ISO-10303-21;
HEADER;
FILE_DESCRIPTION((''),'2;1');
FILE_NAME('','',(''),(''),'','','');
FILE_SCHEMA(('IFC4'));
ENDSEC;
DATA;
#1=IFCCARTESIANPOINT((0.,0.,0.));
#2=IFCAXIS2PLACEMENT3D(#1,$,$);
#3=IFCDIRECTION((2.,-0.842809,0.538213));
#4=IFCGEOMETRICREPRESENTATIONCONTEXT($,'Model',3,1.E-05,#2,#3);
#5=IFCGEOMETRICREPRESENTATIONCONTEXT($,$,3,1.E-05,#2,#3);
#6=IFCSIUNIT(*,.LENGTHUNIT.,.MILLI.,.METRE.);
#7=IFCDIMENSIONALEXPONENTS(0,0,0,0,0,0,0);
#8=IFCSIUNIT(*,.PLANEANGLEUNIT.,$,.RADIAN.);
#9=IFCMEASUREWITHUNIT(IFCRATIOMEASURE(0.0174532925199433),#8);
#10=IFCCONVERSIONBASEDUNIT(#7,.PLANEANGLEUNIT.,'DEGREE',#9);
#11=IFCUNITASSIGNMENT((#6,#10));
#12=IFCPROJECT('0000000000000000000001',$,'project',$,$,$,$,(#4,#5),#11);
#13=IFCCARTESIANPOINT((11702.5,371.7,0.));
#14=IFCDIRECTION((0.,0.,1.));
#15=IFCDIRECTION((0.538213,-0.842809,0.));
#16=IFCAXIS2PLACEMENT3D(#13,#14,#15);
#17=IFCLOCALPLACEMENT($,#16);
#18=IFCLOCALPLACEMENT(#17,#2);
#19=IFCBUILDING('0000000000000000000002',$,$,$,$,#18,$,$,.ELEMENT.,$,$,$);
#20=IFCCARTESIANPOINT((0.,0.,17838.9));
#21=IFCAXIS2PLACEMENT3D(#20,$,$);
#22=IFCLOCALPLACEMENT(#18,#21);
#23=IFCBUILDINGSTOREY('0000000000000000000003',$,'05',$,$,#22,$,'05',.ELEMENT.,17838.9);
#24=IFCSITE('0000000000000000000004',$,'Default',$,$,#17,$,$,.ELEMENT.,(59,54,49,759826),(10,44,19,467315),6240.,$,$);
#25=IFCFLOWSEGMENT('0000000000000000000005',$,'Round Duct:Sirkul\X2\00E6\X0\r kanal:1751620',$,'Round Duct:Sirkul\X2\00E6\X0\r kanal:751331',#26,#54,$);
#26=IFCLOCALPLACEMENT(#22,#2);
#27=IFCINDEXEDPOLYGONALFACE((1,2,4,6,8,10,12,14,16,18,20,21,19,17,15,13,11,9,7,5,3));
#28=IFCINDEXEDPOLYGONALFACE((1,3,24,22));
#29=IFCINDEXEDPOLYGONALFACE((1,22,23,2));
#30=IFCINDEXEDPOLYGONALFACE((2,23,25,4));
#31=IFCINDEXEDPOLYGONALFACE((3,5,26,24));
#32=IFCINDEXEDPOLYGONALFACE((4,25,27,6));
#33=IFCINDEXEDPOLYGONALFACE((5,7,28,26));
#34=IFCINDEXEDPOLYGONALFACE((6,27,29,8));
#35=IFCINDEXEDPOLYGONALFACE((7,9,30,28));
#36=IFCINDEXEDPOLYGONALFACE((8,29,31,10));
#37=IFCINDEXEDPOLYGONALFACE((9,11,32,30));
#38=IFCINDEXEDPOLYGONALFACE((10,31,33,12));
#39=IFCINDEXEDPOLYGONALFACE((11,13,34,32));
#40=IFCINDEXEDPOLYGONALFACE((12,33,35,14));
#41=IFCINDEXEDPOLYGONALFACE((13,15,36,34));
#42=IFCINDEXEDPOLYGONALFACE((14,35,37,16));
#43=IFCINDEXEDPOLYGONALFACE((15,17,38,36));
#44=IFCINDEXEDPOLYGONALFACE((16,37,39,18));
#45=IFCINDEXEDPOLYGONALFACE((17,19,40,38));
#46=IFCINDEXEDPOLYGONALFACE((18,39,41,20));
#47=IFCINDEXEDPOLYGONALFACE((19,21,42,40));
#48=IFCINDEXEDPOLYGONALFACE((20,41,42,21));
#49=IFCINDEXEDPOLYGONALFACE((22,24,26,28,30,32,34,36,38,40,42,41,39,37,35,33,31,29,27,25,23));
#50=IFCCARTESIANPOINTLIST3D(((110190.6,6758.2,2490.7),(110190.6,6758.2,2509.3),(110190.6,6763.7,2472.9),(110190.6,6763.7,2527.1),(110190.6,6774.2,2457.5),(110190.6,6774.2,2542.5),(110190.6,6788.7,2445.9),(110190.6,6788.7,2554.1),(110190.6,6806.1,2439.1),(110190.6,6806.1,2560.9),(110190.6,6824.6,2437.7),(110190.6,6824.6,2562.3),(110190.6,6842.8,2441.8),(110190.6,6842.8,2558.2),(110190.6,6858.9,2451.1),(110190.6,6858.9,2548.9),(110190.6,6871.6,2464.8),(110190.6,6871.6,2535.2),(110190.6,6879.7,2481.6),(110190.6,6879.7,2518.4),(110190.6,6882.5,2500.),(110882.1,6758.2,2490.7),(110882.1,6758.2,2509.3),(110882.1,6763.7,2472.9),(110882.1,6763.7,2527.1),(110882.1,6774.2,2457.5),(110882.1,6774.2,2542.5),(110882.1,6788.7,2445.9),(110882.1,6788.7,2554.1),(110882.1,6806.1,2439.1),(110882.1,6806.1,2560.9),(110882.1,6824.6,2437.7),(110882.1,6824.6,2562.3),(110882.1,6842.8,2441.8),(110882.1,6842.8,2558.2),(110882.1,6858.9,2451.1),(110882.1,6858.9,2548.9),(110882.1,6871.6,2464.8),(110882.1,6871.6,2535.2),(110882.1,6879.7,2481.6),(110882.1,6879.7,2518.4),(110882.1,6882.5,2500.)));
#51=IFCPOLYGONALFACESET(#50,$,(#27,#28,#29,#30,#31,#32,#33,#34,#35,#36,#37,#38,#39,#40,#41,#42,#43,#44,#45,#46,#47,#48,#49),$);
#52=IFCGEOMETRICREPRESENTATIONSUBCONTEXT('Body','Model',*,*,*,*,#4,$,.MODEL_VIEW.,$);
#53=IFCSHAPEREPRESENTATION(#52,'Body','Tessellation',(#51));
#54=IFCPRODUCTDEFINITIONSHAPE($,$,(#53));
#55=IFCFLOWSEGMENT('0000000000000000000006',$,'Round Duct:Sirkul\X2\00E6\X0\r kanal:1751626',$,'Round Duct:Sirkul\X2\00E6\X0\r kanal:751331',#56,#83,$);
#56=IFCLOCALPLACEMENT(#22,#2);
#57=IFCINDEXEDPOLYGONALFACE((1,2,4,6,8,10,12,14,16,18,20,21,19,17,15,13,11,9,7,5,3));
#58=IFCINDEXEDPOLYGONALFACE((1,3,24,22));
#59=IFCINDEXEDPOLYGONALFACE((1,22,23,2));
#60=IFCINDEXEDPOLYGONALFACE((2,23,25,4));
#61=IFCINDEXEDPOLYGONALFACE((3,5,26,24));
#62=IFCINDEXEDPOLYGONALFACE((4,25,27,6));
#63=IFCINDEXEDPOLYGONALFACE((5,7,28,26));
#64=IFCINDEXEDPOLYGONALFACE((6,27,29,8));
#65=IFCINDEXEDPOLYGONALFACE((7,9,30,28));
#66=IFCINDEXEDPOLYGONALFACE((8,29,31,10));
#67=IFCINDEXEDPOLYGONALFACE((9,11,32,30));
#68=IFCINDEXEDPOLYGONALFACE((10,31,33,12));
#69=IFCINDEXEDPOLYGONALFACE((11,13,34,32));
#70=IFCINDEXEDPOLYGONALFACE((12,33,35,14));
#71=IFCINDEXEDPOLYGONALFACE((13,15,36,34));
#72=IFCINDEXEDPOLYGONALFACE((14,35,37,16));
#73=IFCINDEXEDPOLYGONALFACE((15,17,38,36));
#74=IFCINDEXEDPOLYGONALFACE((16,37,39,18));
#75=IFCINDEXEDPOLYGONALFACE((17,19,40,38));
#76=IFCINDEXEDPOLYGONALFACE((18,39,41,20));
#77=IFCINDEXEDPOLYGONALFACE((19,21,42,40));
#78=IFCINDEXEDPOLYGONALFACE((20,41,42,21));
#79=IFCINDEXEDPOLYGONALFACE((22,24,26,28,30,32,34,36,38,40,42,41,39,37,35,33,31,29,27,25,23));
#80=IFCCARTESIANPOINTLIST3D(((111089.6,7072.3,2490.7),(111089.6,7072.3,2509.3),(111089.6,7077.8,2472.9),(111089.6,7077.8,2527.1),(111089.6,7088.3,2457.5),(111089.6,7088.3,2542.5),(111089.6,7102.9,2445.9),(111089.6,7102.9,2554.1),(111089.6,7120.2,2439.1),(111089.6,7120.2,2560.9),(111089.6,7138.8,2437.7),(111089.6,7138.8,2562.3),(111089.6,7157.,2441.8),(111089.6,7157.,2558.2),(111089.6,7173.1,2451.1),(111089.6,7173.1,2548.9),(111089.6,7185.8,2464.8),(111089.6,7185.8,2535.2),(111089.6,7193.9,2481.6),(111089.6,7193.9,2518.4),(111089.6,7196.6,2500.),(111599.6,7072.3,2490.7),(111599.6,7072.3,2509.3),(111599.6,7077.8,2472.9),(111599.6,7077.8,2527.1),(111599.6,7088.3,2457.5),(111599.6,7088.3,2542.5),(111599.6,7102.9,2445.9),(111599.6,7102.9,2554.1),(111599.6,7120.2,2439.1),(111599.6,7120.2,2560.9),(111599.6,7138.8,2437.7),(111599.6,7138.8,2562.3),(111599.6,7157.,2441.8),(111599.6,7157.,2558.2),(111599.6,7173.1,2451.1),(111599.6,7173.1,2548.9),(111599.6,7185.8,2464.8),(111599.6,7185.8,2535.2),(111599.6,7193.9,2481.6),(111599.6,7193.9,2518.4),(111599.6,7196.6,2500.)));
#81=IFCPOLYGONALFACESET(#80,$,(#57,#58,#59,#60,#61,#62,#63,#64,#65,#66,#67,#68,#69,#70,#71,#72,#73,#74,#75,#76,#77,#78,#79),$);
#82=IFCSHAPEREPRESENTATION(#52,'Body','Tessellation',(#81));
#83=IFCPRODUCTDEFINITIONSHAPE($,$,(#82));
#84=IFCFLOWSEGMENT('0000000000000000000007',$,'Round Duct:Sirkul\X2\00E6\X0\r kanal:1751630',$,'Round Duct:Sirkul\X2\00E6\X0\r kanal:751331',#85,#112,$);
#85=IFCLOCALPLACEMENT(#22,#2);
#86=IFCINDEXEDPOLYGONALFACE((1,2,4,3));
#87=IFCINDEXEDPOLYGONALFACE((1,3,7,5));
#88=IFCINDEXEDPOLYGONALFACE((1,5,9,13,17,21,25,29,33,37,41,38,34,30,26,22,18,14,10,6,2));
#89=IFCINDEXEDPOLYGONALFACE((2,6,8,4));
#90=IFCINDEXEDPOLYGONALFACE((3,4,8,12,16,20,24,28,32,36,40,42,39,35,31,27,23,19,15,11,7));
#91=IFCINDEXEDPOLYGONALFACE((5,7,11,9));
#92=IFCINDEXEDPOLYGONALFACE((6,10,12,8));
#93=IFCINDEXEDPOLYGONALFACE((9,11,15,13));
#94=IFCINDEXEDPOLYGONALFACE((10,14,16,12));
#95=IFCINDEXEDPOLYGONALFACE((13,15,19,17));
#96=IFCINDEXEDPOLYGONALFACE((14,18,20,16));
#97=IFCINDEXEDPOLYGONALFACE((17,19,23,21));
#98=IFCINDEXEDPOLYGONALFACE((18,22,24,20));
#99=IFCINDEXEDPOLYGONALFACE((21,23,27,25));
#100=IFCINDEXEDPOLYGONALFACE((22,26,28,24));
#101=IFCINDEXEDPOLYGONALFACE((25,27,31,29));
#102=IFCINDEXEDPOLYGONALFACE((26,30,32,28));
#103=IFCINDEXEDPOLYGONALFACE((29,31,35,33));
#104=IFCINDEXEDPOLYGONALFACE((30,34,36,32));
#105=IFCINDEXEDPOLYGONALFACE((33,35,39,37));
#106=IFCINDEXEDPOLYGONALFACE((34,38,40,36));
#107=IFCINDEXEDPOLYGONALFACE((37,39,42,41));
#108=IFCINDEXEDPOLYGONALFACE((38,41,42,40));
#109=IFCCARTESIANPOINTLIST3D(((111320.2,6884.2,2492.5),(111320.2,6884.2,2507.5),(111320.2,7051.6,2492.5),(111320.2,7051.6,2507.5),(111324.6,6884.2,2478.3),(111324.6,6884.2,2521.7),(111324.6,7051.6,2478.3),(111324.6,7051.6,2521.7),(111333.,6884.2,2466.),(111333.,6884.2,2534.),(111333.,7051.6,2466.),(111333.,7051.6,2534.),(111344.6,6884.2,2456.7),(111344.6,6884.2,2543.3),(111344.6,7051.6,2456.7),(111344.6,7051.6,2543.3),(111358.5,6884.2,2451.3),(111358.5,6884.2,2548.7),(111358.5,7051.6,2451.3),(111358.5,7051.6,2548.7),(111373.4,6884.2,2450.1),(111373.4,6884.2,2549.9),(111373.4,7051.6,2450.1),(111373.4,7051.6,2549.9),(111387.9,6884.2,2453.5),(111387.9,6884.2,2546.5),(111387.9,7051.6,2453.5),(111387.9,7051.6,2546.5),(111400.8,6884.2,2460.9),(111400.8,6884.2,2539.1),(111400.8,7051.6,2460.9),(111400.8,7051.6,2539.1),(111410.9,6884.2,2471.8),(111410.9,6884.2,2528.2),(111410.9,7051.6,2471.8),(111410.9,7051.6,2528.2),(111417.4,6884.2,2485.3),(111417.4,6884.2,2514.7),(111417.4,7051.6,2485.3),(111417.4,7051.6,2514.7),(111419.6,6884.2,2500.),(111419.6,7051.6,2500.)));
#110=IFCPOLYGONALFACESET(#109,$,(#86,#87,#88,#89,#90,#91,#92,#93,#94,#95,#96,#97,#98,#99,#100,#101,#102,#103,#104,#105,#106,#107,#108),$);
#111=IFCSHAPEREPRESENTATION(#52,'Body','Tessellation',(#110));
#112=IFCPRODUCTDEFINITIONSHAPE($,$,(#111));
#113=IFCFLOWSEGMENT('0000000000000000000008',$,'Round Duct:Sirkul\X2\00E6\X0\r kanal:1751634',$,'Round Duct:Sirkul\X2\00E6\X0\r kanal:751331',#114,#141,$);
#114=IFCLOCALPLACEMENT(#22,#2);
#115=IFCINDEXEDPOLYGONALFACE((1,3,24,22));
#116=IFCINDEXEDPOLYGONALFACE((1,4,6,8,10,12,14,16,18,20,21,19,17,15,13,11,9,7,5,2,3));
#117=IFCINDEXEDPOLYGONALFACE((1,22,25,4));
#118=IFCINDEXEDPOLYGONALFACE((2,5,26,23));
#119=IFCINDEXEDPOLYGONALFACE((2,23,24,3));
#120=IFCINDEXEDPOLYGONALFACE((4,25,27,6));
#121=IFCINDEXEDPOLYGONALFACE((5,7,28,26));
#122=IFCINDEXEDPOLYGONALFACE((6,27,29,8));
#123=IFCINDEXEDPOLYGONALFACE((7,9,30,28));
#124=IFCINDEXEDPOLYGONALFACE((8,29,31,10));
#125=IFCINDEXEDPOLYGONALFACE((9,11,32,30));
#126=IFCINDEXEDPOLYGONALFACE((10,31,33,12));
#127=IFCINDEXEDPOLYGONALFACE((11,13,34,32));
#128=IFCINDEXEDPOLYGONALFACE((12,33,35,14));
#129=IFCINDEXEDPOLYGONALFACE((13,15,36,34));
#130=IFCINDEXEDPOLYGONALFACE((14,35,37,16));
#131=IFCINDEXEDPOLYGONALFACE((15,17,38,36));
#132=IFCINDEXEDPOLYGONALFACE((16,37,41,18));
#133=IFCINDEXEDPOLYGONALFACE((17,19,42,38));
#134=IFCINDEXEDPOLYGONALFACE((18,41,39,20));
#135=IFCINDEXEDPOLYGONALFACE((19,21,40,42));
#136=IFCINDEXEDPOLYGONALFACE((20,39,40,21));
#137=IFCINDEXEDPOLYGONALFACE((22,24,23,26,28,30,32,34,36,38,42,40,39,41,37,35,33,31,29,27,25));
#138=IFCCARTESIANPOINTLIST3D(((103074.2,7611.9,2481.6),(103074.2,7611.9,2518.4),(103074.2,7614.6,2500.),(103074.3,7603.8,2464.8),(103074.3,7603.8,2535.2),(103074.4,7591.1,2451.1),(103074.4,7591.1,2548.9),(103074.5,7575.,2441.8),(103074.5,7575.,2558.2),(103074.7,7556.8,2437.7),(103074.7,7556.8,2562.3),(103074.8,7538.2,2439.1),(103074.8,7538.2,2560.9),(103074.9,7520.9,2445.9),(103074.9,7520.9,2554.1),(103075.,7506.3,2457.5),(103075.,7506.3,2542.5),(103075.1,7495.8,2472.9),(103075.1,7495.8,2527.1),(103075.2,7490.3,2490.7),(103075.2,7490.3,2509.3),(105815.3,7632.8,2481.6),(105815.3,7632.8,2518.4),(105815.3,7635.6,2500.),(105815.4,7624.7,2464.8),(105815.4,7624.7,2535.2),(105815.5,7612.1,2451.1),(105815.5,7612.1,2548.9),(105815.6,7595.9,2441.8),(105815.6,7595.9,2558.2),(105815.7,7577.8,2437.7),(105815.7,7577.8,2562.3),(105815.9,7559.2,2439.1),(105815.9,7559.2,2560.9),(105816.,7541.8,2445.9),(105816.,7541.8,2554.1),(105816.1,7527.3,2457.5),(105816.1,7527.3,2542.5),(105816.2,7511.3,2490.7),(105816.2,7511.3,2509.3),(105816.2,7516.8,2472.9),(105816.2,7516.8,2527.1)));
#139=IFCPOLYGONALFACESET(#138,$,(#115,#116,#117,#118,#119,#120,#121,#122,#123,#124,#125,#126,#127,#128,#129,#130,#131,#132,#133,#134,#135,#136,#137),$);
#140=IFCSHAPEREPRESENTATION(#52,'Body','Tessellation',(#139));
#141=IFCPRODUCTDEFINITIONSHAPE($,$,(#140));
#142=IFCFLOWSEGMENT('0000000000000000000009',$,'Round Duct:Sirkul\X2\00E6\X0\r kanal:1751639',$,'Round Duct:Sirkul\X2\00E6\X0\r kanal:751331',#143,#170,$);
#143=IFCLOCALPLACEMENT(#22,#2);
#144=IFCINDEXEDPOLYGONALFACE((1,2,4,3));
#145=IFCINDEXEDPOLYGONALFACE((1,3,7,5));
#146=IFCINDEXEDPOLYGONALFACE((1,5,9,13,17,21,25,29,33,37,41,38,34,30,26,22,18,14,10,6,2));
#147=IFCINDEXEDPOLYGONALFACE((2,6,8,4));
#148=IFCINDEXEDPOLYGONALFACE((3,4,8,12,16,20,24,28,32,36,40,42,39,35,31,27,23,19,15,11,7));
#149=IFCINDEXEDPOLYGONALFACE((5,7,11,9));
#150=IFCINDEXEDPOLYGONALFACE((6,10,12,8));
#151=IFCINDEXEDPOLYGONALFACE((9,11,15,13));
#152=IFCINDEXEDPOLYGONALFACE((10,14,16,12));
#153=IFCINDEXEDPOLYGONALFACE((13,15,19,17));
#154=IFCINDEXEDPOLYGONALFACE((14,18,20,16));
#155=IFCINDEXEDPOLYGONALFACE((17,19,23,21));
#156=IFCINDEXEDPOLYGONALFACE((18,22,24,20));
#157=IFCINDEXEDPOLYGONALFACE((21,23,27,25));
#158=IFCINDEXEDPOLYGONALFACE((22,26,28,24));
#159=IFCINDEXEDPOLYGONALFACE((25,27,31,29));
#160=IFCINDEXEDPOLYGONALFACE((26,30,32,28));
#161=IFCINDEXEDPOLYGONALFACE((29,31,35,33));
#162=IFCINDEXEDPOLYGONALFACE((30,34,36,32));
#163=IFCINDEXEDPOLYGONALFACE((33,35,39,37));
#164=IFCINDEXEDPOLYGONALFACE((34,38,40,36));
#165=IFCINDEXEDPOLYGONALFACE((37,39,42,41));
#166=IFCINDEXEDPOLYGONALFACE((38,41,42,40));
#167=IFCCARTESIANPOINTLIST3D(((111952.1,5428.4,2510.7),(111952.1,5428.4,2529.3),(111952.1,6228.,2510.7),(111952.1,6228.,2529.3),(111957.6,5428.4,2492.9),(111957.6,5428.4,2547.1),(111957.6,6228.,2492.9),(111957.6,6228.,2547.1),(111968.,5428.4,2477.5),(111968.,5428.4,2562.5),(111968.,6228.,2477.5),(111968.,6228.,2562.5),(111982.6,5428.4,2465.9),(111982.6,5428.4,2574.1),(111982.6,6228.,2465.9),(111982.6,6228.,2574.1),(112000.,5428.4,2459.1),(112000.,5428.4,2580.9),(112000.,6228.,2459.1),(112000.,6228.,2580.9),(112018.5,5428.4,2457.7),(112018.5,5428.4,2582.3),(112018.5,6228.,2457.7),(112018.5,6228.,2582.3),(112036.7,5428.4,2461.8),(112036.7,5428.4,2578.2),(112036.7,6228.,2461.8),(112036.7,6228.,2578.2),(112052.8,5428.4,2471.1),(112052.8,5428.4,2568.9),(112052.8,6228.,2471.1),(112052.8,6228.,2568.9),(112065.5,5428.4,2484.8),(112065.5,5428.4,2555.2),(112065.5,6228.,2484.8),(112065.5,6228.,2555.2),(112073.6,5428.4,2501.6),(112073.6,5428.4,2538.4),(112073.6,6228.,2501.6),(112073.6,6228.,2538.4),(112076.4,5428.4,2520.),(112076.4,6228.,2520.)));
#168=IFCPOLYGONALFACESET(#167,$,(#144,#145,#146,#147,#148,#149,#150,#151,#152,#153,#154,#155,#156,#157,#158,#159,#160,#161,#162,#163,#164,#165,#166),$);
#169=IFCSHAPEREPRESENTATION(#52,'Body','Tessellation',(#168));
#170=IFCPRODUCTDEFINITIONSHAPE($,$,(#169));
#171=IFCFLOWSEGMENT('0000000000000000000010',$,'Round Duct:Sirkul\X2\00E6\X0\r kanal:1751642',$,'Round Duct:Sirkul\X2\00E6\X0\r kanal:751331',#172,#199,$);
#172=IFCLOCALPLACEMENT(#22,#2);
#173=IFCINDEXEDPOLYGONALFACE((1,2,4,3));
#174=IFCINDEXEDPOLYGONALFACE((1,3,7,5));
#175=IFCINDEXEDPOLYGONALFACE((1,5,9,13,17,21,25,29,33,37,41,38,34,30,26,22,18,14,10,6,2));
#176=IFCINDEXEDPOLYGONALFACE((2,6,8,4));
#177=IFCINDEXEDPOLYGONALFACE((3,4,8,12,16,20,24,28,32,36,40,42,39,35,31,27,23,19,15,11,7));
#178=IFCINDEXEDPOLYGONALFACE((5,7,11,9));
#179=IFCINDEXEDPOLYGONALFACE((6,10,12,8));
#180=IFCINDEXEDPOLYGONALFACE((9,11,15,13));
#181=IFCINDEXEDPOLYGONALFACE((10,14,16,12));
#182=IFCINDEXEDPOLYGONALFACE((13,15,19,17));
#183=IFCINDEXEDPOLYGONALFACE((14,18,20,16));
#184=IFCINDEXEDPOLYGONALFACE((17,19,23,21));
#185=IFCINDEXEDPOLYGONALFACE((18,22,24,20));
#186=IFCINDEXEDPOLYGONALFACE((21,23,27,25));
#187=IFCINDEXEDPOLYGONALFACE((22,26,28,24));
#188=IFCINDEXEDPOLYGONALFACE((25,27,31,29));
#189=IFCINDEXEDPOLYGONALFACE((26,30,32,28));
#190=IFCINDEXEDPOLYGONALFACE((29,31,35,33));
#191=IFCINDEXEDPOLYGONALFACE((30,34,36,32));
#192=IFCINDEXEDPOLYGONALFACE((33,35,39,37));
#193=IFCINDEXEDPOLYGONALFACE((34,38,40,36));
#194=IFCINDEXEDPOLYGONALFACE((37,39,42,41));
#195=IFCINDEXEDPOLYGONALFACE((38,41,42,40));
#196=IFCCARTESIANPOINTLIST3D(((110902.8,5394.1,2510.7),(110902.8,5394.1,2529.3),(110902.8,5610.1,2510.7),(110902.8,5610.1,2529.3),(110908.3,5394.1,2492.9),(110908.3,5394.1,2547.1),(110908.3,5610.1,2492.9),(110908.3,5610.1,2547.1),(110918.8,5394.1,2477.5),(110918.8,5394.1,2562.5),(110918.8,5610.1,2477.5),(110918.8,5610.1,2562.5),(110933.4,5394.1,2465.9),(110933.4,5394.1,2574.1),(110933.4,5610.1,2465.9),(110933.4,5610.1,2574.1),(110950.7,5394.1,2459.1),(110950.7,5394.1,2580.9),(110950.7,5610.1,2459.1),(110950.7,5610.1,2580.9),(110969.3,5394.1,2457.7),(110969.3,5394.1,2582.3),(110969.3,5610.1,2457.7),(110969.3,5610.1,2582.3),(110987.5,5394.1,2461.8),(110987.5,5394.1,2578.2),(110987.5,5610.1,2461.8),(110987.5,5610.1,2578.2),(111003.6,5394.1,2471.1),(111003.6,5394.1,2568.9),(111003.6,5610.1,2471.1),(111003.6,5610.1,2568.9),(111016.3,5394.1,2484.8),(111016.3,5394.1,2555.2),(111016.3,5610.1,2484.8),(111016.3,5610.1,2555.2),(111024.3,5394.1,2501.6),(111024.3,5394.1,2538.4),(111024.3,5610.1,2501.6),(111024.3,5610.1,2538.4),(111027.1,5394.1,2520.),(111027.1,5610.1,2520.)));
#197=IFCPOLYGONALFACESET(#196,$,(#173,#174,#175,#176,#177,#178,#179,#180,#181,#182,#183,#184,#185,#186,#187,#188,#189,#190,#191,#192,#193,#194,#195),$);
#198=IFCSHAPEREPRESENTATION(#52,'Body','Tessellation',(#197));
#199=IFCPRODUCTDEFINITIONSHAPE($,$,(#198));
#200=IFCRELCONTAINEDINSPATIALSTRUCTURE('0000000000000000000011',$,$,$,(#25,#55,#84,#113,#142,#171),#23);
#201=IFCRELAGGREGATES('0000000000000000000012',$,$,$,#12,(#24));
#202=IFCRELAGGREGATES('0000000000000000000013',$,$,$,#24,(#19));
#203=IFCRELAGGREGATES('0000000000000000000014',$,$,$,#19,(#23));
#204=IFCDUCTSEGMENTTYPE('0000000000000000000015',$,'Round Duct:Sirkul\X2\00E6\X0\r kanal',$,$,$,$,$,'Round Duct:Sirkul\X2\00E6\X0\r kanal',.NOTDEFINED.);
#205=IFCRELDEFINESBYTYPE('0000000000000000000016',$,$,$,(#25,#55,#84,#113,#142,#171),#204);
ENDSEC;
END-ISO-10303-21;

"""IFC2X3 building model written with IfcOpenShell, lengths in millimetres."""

from ifc_helpers import new_model, entity, si_unit, converted_unit, direction, frame, frame_2d, origin, origin_2d_with_axis, place, context, subcontext, project, spatial, circle, extrude, type_object, element, save


model = new_model("IFC2X3")

# Units and contexts
model_context = context("Model", 3, precision=1e-05, world=origin(), true_north=direction((2.0, -0.842809, 0.538213)))
context_of_model = context(None, 3, precision=1e-05, world=origin(), true_north=direction((2.0, -0.842809, 0.538213)))
body_context = subcontext(model_context, "Body", "Model", "MODEL_VIEW")
ifc_project = project(units=[si_unit("LENGTHUNIT", "METRE", prefix="MILLI"), converted_unit("PLANEANGLEUNIT", "DEGREE", entity("IfcRatioMeasure", 0.0174532925199433), si_unit("PLANEANGLEUNIT", "RADIAN"), dimensions=[0, 0, 0, 0, 0, 0, 0])], contexts=[model_context, context_of_model])

# Site, building, storey
site_placement = place(None, frame((11702.5, 371.7, 0.0), z_axis=(0.0, 0.0, 1.0), x_axis=(0.538213, -0.842809, 0.0)))
site = spatial("IfcSite", under=ifc_project, at=site_placement, Name="Default", CompositionType="ELEMENT", RefLatitude=(59, 54, 49, 759826), RefLongitude=(10, 44, 19, 467315), RefElevation=6240.0)
building_placement = place(site_placement, origin())
building = spatial("IfcBuilding", under=site, at=building_placement, CompositionType="ELEMENT")
storey_placement = place(building_placement, frame((0.0, 0.0, 17838.9)))
storey = spatial("IfcBuildingStorey", under=building, at=storey_placement, Name="05", LongName="05", CompositionType="ELEMENT", Elevation=17838.9)

# Flow segments
duct_segment_type = type_object("IfcDuctSegmentType", Name="Round Duct:Sirkulær kanal", ElementType="Round Duct:Sirkulær kanal", PredefinedType="NOTDEFINED")
flow_segment_1_placement = place(storey_placement, origin())
element("IfcFlowSegment", 1, at=flow_segment_1_placement, inside=storey, type_object=duct_segment_type, Name="Round Duct:Sirkulær kanal:1751620", ObjectType="Round Duct:Sirkulær kanal:751331", context=body_context, shape_type="SweptSolid", body=[
    extrude(circle(Radius=62.5, at=frame_2d((0.0, 0.0), x_axis=(1.0, 0.0))), frame((110190.6, 6820.0, 2500.0), z_axis=(1.0, 0.0, 0.0), x_axis=(0.0, 1.0, 0.0)), (0.0, 0.0, 1.0), 691.5),
])
flow_segment_2_placement = place(storey_placement, origin())
element("IfcFlowSegment", 2, at=flow_segment_2_placement, inside=storey, type_object=duct_segment_type, Name="Round Duct:Sirkulær kanal:1751626", ObjectType="Round Duct:Sirkulær kanal:751331", context=body_context, shape_type="SweptSolid", body=[
    extrude(circle(Radius=62.5, at=origin_2d_with_axis()), frame((111089.6, 7134.1, 2500.0), z_axis=(1.0, 0.000001, 0.0), x_axis=(-0.000001, 1.0, 0.0)), (0.0, 0.0, 1.0), 510.0),
])
flow_segment_3_placement = place(storey_placement, origin())
element("IfcFlowSegment", 3, at=flow_segment_3_placement, inside=storey, type_object=duct_segment_type, Name="Round Duct:Sirkulær kanal:1751630", ObjectType="Round Duct:Sirkulær kanal:751331", context=body_context, shape_type="SweptSolid", body=[
    extrude(circle(Radius=50.0, at=origin_2d_with_axis()), frame((111369.6, 6884.2, 2500.0), z_axis=(0.0, 1.0, 0.0), x_axis=(1.0, 0.0, 0.0)), (0.0, 0.0, 1.0), 167.5),
])
flow_segment_4_placement = place(storey_placement, origin())
element("IfcFlowSegment", 4, at=flow_segment_4_placement, inside=storey, type_object=duct_segment_type, Name="Round Duct:Sirkulær kanal:1751634", ObjectType="Round Duct:Sirkulær kanal:751331", context=body_context, shape_type="SweptSolid", body=[
    extrude(circle(Radius=62.5, at=origin_2d_with_axis()), frame((103074.7, 7552.1, 2500.0), z_axis=(0.999971, 0.007643, 0.0), x_axis=(-0.007643, 0.999971, 0.0)), (0.0, 0.0, 1.0), 2741.2),
])
flow_segment_5_placement = place(storey_placement, origin())
element("IfcFlowSegment", 5, at=flow_segment_5_placement, inside=storey, type_object=duct_segment_type, Name="Round Duct:Sirkulær kanal:1751639", ObjectType="Round Duct:Sirkulær kanal:751331", context=body_context, shape_type="SweptSolid", body=[
    extrude(circle(Radius=62.5, at=frame_2d((0.0, 0.0), x_axis=(1.0, 0.0))), frame((112013.9, 5428.4, 2520.0), z_axis=(0.000003, 1.0, 0.0), x_axis=(1.0, -0.000003, 0.0)), (0.0, 0.0, 1.0), 799.6),
])
flow_segment_6_placement = place(storey_placement, origin())
element("IfcFlowSegment", 6, at=flow_segment_6_placement, inside=storey, type_object=duct_segment_type, Name="Round Duct:Sirkulær kanal:1751642", ObjectType="Round Duct:Sirkulær kanal:751331", context=body_context, shape_type="SweptSolid", body=[
    extrude(circle(Radius=62.5, at=frame_2d((0.0, 0.0), x_axis=(1.0, 0.0))), frame((110964.6, 5394.1, 2520.0), z_axis=(0.0, 1.0, 0.0), x_axis=(1.0, 0.0, 0.0)), (0.0, 0.0, 1.0), 216.0),
])

save(model, "model.ifc")
